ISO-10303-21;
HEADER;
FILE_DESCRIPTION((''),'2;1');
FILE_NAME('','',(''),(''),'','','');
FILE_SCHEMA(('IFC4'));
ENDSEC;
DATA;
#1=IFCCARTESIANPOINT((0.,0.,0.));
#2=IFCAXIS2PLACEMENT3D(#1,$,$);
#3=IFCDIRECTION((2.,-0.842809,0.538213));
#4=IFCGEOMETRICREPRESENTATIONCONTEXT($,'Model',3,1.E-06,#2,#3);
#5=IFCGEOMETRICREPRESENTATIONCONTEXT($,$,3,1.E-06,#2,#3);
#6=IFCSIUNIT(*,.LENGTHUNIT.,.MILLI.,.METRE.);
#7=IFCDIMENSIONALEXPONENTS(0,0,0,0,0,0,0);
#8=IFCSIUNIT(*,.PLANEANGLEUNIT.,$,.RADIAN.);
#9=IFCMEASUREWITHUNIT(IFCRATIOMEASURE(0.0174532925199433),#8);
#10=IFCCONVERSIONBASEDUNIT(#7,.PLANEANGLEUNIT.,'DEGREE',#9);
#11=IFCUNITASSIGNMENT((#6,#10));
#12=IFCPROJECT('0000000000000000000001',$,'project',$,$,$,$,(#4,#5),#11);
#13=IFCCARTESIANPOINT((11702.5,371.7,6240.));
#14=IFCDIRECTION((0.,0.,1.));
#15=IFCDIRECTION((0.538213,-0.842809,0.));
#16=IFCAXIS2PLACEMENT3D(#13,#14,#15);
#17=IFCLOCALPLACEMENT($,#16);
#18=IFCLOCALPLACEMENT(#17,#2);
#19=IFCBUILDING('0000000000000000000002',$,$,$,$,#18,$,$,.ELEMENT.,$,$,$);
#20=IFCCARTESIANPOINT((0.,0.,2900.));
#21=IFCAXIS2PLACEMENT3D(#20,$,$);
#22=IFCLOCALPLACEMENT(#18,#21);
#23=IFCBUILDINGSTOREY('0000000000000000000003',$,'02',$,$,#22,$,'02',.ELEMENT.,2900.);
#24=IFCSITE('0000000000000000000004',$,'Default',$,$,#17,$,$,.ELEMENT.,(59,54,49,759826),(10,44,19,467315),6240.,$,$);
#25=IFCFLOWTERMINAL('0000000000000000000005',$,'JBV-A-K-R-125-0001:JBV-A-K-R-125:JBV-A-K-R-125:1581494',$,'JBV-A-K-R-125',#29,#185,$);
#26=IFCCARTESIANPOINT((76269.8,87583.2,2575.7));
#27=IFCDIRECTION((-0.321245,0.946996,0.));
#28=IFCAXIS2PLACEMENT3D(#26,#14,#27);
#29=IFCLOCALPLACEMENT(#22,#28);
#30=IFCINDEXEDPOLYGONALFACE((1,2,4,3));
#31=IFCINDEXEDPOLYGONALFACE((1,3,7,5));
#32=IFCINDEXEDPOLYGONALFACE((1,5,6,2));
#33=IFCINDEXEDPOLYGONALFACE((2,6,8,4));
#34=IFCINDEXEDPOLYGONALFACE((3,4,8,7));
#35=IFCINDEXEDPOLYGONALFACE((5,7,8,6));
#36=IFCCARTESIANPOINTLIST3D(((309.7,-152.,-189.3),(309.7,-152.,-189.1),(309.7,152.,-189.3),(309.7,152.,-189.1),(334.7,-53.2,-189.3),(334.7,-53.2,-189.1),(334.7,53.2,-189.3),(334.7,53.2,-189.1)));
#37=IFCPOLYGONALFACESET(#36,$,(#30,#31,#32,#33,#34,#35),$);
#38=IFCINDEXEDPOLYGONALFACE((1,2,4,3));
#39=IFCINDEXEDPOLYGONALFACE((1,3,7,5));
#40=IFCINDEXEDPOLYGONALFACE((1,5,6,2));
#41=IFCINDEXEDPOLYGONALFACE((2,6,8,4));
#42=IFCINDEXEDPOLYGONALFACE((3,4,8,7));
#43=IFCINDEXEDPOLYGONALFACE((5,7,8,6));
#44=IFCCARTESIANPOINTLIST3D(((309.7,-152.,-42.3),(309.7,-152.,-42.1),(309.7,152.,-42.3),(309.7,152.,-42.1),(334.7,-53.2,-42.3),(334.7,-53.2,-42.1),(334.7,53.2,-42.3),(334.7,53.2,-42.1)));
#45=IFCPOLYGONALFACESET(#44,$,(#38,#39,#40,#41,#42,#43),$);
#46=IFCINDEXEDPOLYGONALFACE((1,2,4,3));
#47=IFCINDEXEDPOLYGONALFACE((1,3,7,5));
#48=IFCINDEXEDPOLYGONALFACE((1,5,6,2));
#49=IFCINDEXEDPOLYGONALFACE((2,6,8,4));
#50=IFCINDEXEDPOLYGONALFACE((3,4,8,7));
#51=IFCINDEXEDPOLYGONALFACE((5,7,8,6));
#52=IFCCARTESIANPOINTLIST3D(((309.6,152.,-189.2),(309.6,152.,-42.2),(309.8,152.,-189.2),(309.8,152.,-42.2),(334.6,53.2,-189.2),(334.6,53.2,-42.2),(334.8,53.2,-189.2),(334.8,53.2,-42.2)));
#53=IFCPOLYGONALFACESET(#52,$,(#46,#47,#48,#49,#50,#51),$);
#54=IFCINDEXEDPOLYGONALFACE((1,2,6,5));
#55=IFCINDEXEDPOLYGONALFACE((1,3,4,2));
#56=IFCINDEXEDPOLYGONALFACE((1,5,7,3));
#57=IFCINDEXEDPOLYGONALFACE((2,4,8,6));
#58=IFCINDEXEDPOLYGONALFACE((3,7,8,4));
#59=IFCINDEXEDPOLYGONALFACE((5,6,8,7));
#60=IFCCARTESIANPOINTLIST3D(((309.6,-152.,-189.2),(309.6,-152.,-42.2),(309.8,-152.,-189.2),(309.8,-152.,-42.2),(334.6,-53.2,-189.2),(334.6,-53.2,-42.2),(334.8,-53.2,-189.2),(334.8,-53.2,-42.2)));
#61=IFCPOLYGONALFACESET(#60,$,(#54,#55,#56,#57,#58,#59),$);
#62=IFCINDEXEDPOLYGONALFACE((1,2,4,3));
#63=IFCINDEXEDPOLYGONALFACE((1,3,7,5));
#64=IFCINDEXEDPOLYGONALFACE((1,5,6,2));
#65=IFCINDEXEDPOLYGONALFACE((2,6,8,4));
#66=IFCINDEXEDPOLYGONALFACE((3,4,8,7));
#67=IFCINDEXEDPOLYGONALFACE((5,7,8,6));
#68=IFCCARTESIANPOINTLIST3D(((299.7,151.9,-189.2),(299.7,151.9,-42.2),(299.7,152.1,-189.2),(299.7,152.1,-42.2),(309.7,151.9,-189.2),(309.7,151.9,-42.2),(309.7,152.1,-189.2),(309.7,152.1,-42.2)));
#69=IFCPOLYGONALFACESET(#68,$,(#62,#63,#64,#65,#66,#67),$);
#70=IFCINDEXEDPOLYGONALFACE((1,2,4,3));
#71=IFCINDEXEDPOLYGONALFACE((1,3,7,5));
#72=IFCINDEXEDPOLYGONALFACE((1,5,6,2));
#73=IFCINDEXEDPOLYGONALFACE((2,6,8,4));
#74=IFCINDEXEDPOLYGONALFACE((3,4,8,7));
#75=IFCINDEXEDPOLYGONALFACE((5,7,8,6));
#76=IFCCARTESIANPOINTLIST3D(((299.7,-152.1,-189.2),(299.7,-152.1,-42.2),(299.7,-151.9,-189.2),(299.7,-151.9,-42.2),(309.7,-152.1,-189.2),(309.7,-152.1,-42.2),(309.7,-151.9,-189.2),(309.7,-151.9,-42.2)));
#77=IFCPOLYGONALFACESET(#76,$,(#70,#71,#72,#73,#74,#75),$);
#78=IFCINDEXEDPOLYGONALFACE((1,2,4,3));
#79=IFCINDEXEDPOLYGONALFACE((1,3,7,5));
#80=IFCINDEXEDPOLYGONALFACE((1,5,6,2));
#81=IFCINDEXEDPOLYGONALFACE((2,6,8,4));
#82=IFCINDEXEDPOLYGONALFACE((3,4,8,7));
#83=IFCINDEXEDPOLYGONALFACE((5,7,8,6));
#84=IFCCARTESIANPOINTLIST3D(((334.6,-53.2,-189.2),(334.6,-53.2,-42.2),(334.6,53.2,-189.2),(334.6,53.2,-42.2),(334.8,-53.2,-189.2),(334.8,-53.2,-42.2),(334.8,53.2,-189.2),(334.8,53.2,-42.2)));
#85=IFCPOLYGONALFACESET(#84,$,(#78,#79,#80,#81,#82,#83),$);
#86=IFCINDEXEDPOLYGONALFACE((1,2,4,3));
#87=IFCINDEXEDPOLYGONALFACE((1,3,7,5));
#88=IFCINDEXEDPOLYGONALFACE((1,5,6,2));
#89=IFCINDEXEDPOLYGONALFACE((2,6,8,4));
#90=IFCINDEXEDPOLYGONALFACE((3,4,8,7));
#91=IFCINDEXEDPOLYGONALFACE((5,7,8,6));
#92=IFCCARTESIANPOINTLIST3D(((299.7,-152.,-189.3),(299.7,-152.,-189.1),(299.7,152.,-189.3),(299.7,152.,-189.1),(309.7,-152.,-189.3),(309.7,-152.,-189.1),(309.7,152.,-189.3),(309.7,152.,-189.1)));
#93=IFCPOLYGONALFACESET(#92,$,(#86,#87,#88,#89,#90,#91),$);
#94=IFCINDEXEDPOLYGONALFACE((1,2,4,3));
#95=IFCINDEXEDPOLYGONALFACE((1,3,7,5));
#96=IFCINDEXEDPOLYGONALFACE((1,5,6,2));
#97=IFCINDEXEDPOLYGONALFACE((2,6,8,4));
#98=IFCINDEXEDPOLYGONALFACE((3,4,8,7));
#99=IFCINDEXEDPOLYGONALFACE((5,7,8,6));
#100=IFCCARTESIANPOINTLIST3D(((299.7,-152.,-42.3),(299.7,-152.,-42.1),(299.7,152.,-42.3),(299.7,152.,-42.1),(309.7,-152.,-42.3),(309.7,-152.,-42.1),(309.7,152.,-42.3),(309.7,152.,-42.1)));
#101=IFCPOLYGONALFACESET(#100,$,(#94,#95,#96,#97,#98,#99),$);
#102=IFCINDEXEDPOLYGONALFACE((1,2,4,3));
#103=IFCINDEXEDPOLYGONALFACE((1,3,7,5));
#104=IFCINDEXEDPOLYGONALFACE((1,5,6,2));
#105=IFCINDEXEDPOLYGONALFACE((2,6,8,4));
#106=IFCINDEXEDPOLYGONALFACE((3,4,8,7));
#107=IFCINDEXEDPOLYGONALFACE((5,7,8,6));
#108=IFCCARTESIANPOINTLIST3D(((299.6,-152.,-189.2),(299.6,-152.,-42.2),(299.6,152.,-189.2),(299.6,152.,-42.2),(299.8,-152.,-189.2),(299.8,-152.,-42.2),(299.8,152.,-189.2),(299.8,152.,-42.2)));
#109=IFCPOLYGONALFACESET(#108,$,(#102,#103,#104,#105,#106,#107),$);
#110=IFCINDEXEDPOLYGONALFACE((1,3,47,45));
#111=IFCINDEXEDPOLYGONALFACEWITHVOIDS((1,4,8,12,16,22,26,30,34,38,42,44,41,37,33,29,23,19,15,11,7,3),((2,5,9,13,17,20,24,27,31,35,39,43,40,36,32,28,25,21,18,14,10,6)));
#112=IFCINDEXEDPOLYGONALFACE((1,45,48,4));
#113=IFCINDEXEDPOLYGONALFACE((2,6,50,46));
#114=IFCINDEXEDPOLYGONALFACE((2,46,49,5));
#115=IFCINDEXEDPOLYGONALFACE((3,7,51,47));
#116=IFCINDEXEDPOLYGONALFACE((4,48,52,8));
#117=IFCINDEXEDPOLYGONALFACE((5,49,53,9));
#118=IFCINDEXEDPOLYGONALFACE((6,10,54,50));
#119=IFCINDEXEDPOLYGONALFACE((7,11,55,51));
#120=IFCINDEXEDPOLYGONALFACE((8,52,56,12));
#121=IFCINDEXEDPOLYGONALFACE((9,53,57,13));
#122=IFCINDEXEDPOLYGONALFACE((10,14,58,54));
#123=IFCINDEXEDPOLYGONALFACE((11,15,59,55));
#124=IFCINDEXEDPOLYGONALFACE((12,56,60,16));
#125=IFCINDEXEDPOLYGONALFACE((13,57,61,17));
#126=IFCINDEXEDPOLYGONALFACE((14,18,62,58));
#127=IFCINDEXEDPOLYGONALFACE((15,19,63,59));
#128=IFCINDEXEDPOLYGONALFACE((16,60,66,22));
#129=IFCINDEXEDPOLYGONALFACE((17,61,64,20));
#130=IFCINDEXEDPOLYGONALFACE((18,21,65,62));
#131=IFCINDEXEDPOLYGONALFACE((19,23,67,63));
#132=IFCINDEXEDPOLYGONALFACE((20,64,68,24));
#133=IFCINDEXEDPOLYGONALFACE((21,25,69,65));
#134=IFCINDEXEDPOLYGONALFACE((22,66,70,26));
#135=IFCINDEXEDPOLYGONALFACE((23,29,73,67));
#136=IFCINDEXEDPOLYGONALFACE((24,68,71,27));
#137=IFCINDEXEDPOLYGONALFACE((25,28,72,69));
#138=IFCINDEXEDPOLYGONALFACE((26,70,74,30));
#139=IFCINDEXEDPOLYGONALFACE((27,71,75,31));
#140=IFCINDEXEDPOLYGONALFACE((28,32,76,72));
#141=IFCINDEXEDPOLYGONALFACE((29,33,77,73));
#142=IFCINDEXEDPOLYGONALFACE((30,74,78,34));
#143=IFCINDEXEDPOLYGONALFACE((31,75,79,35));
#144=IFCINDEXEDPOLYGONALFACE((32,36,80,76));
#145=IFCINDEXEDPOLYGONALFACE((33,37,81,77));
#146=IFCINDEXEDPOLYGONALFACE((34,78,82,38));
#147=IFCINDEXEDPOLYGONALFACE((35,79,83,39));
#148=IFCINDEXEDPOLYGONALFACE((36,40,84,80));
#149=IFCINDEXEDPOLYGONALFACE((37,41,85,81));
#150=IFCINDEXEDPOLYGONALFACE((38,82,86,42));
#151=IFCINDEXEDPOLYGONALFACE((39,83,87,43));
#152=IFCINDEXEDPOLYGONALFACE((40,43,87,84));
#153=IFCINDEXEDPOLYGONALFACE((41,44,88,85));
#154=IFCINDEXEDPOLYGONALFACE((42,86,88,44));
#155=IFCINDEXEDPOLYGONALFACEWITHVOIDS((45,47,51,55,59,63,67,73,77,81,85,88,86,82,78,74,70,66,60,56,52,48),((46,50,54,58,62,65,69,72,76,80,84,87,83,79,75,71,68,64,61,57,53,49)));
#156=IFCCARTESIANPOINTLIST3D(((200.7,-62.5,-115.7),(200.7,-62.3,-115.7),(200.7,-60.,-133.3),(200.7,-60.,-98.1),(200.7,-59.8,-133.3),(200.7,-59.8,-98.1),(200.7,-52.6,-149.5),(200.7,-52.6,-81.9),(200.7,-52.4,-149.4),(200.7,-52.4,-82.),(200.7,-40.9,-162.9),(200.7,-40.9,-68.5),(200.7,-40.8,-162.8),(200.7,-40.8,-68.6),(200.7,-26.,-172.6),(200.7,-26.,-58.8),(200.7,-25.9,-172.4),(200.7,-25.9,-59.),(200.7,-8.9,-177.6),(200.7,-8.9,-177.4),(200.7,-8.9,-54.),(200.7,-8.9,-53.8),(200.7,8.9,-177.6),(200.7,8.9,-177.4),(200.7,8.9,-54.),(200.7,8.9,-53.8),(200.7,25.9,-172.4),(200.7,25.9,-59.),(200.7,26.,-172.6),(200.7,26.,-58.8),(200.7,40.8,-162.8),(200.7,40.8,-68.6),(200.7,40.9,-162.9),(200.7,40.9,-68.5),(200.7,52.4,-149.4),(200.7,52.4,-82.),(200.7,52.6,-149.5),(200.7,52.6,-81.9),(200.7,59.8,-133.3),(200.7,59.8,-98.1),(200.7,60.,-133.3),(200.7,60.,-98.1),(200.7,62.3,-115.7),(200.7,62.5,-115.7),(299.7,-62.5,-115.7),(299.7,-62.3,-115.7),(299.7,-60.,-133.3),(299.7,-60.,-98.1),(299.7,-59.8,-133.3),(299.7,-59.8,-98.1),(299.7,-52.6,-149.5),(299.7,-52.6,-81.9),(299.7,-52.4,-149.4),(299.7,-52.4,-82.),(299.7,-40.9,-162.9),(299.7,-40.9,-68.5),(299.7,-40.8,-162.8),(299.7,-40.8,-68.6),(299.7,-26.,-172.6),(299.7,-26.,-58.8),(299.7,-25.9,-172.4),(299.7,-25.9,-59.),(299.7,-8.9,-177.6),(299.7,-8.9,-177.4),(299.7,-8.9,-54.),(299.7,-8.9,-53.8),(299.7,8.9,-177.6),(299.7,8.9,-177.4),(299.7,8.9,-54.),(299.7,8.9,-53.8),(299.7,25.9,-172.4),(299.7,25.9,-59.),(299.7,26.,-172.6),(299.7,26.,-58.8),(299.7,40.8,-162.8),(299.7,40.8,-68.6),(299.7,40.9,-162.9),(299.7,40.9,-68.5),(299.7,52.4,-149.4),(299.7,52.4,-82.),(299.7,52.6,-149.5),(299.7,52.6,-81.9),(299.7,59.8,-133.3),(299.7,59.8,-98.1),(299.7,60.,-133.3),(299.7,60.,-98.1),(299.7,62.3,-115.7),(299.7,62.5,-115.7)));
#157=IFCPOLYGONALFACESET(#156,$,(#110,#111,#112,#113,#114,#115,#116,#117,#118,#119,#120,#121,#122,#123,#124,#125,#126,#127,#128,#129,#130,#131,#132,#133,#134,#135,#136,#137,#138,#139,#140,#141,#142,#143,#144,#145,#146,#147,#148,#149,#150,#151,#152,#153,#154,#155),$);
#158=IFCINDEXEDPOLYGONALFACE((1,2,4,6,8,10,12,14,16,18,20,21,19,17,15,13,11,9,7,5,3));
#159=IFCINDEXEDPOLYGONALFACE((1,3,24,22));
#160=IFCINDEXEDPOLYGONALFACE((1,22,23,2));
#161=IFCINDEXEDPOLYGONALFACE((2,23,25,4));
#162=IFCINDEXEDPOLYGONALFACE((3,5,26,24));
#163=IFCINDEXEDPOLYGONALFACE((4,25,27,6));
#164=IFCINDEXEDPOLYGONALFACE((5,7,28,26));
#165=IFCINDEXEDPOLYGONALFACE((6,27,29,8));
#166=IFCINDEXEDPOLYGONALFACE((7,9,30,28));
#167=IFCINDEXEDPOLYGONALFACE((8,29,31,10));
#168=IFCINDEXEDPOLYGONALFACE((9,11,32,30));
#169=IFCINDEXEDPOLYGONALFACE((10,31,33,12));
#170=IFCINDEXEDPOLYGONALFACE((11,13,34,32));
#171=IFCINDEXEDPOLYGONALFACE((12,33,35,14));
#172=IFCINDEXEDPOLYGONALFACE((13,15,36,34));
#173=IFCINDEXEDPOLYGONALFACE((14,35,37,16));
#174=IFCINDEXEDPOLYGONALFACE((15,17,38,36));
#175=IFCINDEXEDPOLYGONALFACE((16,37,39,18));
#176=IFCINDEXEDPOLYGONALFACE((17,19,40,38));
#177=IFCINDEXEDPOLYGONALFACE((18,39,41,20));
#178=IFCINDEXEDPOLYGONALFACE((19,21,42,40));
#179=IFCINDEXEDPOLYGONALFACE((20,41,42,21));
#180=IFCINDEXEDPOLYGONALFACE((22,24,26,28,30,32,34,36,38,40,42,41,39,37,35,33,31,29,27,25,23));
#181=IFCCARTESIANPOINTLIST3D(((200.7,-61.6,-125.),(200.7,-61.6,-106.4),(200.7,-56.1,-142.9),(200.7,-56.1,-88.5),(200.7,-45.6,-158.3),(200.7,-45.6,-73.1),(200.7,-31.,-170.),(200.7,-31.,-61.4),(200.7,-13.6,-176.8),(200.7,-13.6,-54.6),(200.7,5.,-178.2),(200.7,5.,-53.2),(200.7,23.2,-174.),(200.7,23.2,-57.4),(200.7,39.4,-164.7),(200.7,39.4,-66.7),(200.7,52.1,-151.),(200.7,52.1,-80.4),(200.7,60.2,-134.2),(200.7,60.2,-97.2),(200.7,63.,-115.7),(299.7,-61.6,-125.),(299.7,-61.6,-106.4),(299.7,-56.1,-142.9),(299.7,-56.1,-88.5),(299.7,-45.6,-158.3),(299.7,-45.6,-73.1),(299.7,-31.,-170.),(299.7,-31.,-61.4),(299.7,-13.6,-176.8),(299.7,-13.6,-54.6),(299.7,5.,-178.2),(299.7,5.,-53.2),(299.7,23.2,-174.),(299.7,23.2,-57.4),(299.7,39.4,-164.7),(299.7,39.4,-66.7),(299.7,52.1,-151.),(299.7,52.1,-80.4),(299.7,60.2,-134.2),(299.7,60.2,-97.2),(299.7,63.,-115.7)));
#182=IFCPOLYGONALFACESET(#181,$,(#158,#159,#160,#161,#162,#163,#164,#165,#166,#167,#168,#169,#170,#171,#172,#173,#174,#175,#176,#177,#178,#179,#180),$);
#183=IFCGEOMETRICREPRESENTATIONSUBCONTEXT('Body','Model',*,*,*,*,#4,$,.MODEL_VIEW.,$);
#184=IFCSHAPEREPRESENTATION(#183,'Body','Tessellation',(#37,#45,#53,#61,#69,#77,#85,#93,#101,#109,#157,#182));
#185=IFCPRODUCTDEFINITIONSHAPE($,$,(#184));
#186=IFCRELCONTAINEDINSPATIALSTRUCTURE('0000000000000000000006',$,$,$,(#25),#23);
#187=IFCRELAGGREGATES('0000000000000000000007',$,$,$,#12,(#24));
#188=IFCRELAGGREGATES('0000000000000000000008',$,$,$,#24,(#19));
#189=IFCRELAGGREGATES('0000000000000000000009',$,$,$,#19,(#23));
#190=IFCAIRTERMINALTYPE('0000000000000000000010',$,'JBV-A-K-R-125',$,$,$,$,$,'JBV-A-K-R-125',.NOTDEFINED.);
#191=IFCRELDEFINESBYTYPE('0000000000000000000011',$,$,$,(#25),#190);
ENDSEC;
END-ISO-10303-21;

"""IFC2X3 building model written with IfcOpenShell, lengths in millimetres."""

from ifc_helpers import new_model, entity, si_unit, converted_unit, direction, frame, frame_2d, origin, origin_2d_with_axis, place, context, subcontext, project, spatial, polyline, circle_curve, parameter, trimmed, segment, composite_curve, rectangle, circle, outline, extrude, source, transform, mapped, type_object, type_shapes, element, save


model = new_model("IFC2X3")

# Units and contexts
model_context = context("Model", 3, precision=1e-06, world=origin(), true_north=direction((2.0, -0.842809, 0.538213)))
context_of_model = context(None, 3, precision=1e-06, world=origin(), true_north=direction((2.0, -0.842809, 0.538213)))
body_context = subcontext(model_context, "Body", "Model", "MODEL_VIEW")
ifc_project = project(units=[si_unit("LENGTHUNIT", "METRE", prefix="MILLI"), converted_unit("PLANEANGLEUNIT", "DEGREE", entity("IfcRatioMeasure", 0.0174532925199433), si_unit("PLANEANGLEUNIT", "RADIAN"), dimensions=[0, 0, 0, 0, 0, 0, 0])], contexts=[model_context, context_of_model])

# Site, building, storey
site_placement = place(None, frame((11702.5, 371.7, 6240.0), z_axis=(0.0, 0.0, 1.0), x_axis=(0.538213, -0.842809, 0.0)))
site = spatial("IfcSite", under=ifc_project, at=site_placement, Name="Default", CompositionType="ELEMENT", RefLatitude=(59, 54, 49, 759826), RefLongitude=(10, 44, 19, 467315), RefElevation=6240.0)
building_placement = place(site_placement, origin())
building = spatial("IfcBuilding", under=site, at=building_placement, CompositionType="ELEMENT")
storey_placement = place(building_placement, frame((0.0, 0.0, 2900.0)))
storey = spatial("IfcBuildingStorey", under=building, at=storey_placement, Name="02", LongName="02", CompositionType="ELEMENT", Elevation=2900.0)

# Flow terminal
air_terminal_type_1 = type_object("IfcAirTerminalType", Name="JBV-A-K-R-125", ElementType="JBV-A-K-R-125", PredefinedType="NOTDEFINED")
shared_shape_1 = source(origin(), body_context, "Body", "SweptSolid", [
    extrude(outline(polyline([(-152.0, -12.5), (152.0, -12.5), (53.2, 12.5), (-53.2, 12.5), (-152.0, -12.5)])), frame((322.2, 0.0, -189.3), z_axis=(0.0, 0.0, 1.0), x_axis=(0.0, -1.0, 0.0)), (0.0, 0.0, 1.0), 0.2),
    extrude(outline(polyline([(-152.0, -12.5), (152.0, -12.5), (53.2, 12.5), (-53.2, 12.5), (-152.0, -12.5)])), frame((322.2, 0.0, -42.3), z_axis=(0.0, 0.0, 1.0), x_axis=(0.0, -1.0, 0.0)), (0.0, 0.0, 1.0), 0.2),
    extrude(rectangle(XDim=0.2, YDim=101.9, at=frame_2d((0.0, 0.0), x_axis=(1.0, 0.0))), frame((322.2, 102.6, -189.2), z_axis=(0.0, 0.0, 1.0), x_axis=(0.969446, 0.245305, 0.0)), (0.0, 0.0, 1.0), 147.0),
    extrude(rectangle(XDim=0.2, YDim=101.9, at=frame_2d((0.0, 0.0), x_axis=(1.0, 0.0))), frame((322.2, -102.6, -189.2), z_axis=(0.0, 0.0, 1.0), x_axis=(-0.969446, 0.245305, 0.0)), (0.0, 0.0, 1.0), 147.0),
    extrude(rectangle(XDim=0.2, YDim=10.0, at=frame_2d((0.0, 0.0), x_axis=(1.0, 0.0))), frame((304.7, 152.0, -189.2), z_axis=(0.0, 0.0, 1.0), x_axis=(0.0, 1.0, 0.0)), (0.0, 0.0, 1.0), 147.0),
    extrude(rectangle(XDim=0.2, YDim=10.0, at=frame_2d((0.0, 0.0), x_axis=(1.0, 0.0))), frame((304.7, -152.0, -189.2), z_axis=(0.0, 0.0, 1.0), x_axis=(0.0, 1.0, 0.0)), (0.0, 0.0, 1.0), 147.0),
    extrude(rectangle(XDim=0.2, YDim=106.4, at=frame_2d((0.0, 0.0), x_axis=(1.0, 0.0))), frame((334.7, 0.0, -189.2)), (0.0, 0.0, 1.0), 147.0),
    extrude(rectangle(XDim=304.0, YDim=10.0, at=frame_2d((0.0, 0.0), x_axis=(1.0, 0.0))), frame((304.7, 0.0, -189.3), z_axis=(0.0, 0.0, 1.0), x_axis=(0.0, -1.0, 0.0)), (0.0, 0.0, 1.0), 0.2),
    extrude(rectangle(XDim=304.0, YDim=10.0, at=frame_2d((0.0, 0.0), x_axis=(1.0, 0.0))), frame((304.7, 0.0, -42.3), z_axis=(0.0, 0.0, 1.0), x_axis=(0.0, -1.0, 0.0)), (0.0, 0.0, 1.0), 0.2),
    extrude(rectangle(XDim=0.2, YDim=304.0, at=frame_2d((0.0, 0.0), x_axis=(1.0, 0.0))), frame((299.7, 0.0, -189.2)), (0.0, 0.0, 1.0), 147.0),
    extrude(outline(composite_curve([segment(trimmed(circle_curve(origin_2d_with_axis(), 62.5), [parameter(0.0)], [parameter(180.0)], True, "PARAMETER"), True, "CONTINUOUS"), segment(trimmed(circle_curve(origin_2d_with_axis(), 62.5), [parameter(180.0)], [parameter(360.0)], True, "PARAMETER"), True, "CONTINUOUS")], self_intersect=False), holes=[composite_curve([segment(trimmed(circle_curve(origin_2d_with_axis(), 62.3), [parameter(180.0)], [parameter(360.0)], True, "PARAMETER"), False, "CONTINUOUS"), segment(trimmed(circle_curve(origin_2d_with_axis(), 62.3), [parameter(0.0)], [parameter(180.0)], True, "PARAMETER"), False, "CONTINUOUS")], self_intersect=False)]), frame((200.7, 0.0, -115.7), z_axis=(1.0, 0.0, 0.0), x_axis=(0.0, 1.0, 0.0)), (0.0, 0.0, 1.0), 99.0),
    extrude(circle(Radius=62.6, at=frame_2d((0.0, 0.0), x_axis=(1.0, 0.0))), frame((200.7, 0.3, -115.7), z_axis=(1.0, 0.0, 0.0), x_axis=(0.0, 1.0, 0.0)), (0.0, 0.0, 1.0), 99.0),
])
type_shapes(air_terminal_type_1, [shared_shape_1])
flow_terminal_1_placement = place(storey_placement, frame((76269.8, 87583.2, 2575.7), z_axis=(0.0, 0.0, 1.0), x_axis=(-0.321245, 0.946996, 0.0)))
element("IfcFlowTerminal", 1, at=flow_terminal_1_placement, inside=storey, type_object=air_terminal_type_1, Name="JBV-A-K-R-125-0001:JBV-A-K-R-125:JBV-A-K-R-125:1581494", ObjectType="JBV-A-K-R-125", context=body_context, shape_type="MappedRepresentation", body=[
    mapped(shared_shape_1, transform((0.0, 0.0, 0.0), scale=1.0)),
])

save(model, "model.ifc")
